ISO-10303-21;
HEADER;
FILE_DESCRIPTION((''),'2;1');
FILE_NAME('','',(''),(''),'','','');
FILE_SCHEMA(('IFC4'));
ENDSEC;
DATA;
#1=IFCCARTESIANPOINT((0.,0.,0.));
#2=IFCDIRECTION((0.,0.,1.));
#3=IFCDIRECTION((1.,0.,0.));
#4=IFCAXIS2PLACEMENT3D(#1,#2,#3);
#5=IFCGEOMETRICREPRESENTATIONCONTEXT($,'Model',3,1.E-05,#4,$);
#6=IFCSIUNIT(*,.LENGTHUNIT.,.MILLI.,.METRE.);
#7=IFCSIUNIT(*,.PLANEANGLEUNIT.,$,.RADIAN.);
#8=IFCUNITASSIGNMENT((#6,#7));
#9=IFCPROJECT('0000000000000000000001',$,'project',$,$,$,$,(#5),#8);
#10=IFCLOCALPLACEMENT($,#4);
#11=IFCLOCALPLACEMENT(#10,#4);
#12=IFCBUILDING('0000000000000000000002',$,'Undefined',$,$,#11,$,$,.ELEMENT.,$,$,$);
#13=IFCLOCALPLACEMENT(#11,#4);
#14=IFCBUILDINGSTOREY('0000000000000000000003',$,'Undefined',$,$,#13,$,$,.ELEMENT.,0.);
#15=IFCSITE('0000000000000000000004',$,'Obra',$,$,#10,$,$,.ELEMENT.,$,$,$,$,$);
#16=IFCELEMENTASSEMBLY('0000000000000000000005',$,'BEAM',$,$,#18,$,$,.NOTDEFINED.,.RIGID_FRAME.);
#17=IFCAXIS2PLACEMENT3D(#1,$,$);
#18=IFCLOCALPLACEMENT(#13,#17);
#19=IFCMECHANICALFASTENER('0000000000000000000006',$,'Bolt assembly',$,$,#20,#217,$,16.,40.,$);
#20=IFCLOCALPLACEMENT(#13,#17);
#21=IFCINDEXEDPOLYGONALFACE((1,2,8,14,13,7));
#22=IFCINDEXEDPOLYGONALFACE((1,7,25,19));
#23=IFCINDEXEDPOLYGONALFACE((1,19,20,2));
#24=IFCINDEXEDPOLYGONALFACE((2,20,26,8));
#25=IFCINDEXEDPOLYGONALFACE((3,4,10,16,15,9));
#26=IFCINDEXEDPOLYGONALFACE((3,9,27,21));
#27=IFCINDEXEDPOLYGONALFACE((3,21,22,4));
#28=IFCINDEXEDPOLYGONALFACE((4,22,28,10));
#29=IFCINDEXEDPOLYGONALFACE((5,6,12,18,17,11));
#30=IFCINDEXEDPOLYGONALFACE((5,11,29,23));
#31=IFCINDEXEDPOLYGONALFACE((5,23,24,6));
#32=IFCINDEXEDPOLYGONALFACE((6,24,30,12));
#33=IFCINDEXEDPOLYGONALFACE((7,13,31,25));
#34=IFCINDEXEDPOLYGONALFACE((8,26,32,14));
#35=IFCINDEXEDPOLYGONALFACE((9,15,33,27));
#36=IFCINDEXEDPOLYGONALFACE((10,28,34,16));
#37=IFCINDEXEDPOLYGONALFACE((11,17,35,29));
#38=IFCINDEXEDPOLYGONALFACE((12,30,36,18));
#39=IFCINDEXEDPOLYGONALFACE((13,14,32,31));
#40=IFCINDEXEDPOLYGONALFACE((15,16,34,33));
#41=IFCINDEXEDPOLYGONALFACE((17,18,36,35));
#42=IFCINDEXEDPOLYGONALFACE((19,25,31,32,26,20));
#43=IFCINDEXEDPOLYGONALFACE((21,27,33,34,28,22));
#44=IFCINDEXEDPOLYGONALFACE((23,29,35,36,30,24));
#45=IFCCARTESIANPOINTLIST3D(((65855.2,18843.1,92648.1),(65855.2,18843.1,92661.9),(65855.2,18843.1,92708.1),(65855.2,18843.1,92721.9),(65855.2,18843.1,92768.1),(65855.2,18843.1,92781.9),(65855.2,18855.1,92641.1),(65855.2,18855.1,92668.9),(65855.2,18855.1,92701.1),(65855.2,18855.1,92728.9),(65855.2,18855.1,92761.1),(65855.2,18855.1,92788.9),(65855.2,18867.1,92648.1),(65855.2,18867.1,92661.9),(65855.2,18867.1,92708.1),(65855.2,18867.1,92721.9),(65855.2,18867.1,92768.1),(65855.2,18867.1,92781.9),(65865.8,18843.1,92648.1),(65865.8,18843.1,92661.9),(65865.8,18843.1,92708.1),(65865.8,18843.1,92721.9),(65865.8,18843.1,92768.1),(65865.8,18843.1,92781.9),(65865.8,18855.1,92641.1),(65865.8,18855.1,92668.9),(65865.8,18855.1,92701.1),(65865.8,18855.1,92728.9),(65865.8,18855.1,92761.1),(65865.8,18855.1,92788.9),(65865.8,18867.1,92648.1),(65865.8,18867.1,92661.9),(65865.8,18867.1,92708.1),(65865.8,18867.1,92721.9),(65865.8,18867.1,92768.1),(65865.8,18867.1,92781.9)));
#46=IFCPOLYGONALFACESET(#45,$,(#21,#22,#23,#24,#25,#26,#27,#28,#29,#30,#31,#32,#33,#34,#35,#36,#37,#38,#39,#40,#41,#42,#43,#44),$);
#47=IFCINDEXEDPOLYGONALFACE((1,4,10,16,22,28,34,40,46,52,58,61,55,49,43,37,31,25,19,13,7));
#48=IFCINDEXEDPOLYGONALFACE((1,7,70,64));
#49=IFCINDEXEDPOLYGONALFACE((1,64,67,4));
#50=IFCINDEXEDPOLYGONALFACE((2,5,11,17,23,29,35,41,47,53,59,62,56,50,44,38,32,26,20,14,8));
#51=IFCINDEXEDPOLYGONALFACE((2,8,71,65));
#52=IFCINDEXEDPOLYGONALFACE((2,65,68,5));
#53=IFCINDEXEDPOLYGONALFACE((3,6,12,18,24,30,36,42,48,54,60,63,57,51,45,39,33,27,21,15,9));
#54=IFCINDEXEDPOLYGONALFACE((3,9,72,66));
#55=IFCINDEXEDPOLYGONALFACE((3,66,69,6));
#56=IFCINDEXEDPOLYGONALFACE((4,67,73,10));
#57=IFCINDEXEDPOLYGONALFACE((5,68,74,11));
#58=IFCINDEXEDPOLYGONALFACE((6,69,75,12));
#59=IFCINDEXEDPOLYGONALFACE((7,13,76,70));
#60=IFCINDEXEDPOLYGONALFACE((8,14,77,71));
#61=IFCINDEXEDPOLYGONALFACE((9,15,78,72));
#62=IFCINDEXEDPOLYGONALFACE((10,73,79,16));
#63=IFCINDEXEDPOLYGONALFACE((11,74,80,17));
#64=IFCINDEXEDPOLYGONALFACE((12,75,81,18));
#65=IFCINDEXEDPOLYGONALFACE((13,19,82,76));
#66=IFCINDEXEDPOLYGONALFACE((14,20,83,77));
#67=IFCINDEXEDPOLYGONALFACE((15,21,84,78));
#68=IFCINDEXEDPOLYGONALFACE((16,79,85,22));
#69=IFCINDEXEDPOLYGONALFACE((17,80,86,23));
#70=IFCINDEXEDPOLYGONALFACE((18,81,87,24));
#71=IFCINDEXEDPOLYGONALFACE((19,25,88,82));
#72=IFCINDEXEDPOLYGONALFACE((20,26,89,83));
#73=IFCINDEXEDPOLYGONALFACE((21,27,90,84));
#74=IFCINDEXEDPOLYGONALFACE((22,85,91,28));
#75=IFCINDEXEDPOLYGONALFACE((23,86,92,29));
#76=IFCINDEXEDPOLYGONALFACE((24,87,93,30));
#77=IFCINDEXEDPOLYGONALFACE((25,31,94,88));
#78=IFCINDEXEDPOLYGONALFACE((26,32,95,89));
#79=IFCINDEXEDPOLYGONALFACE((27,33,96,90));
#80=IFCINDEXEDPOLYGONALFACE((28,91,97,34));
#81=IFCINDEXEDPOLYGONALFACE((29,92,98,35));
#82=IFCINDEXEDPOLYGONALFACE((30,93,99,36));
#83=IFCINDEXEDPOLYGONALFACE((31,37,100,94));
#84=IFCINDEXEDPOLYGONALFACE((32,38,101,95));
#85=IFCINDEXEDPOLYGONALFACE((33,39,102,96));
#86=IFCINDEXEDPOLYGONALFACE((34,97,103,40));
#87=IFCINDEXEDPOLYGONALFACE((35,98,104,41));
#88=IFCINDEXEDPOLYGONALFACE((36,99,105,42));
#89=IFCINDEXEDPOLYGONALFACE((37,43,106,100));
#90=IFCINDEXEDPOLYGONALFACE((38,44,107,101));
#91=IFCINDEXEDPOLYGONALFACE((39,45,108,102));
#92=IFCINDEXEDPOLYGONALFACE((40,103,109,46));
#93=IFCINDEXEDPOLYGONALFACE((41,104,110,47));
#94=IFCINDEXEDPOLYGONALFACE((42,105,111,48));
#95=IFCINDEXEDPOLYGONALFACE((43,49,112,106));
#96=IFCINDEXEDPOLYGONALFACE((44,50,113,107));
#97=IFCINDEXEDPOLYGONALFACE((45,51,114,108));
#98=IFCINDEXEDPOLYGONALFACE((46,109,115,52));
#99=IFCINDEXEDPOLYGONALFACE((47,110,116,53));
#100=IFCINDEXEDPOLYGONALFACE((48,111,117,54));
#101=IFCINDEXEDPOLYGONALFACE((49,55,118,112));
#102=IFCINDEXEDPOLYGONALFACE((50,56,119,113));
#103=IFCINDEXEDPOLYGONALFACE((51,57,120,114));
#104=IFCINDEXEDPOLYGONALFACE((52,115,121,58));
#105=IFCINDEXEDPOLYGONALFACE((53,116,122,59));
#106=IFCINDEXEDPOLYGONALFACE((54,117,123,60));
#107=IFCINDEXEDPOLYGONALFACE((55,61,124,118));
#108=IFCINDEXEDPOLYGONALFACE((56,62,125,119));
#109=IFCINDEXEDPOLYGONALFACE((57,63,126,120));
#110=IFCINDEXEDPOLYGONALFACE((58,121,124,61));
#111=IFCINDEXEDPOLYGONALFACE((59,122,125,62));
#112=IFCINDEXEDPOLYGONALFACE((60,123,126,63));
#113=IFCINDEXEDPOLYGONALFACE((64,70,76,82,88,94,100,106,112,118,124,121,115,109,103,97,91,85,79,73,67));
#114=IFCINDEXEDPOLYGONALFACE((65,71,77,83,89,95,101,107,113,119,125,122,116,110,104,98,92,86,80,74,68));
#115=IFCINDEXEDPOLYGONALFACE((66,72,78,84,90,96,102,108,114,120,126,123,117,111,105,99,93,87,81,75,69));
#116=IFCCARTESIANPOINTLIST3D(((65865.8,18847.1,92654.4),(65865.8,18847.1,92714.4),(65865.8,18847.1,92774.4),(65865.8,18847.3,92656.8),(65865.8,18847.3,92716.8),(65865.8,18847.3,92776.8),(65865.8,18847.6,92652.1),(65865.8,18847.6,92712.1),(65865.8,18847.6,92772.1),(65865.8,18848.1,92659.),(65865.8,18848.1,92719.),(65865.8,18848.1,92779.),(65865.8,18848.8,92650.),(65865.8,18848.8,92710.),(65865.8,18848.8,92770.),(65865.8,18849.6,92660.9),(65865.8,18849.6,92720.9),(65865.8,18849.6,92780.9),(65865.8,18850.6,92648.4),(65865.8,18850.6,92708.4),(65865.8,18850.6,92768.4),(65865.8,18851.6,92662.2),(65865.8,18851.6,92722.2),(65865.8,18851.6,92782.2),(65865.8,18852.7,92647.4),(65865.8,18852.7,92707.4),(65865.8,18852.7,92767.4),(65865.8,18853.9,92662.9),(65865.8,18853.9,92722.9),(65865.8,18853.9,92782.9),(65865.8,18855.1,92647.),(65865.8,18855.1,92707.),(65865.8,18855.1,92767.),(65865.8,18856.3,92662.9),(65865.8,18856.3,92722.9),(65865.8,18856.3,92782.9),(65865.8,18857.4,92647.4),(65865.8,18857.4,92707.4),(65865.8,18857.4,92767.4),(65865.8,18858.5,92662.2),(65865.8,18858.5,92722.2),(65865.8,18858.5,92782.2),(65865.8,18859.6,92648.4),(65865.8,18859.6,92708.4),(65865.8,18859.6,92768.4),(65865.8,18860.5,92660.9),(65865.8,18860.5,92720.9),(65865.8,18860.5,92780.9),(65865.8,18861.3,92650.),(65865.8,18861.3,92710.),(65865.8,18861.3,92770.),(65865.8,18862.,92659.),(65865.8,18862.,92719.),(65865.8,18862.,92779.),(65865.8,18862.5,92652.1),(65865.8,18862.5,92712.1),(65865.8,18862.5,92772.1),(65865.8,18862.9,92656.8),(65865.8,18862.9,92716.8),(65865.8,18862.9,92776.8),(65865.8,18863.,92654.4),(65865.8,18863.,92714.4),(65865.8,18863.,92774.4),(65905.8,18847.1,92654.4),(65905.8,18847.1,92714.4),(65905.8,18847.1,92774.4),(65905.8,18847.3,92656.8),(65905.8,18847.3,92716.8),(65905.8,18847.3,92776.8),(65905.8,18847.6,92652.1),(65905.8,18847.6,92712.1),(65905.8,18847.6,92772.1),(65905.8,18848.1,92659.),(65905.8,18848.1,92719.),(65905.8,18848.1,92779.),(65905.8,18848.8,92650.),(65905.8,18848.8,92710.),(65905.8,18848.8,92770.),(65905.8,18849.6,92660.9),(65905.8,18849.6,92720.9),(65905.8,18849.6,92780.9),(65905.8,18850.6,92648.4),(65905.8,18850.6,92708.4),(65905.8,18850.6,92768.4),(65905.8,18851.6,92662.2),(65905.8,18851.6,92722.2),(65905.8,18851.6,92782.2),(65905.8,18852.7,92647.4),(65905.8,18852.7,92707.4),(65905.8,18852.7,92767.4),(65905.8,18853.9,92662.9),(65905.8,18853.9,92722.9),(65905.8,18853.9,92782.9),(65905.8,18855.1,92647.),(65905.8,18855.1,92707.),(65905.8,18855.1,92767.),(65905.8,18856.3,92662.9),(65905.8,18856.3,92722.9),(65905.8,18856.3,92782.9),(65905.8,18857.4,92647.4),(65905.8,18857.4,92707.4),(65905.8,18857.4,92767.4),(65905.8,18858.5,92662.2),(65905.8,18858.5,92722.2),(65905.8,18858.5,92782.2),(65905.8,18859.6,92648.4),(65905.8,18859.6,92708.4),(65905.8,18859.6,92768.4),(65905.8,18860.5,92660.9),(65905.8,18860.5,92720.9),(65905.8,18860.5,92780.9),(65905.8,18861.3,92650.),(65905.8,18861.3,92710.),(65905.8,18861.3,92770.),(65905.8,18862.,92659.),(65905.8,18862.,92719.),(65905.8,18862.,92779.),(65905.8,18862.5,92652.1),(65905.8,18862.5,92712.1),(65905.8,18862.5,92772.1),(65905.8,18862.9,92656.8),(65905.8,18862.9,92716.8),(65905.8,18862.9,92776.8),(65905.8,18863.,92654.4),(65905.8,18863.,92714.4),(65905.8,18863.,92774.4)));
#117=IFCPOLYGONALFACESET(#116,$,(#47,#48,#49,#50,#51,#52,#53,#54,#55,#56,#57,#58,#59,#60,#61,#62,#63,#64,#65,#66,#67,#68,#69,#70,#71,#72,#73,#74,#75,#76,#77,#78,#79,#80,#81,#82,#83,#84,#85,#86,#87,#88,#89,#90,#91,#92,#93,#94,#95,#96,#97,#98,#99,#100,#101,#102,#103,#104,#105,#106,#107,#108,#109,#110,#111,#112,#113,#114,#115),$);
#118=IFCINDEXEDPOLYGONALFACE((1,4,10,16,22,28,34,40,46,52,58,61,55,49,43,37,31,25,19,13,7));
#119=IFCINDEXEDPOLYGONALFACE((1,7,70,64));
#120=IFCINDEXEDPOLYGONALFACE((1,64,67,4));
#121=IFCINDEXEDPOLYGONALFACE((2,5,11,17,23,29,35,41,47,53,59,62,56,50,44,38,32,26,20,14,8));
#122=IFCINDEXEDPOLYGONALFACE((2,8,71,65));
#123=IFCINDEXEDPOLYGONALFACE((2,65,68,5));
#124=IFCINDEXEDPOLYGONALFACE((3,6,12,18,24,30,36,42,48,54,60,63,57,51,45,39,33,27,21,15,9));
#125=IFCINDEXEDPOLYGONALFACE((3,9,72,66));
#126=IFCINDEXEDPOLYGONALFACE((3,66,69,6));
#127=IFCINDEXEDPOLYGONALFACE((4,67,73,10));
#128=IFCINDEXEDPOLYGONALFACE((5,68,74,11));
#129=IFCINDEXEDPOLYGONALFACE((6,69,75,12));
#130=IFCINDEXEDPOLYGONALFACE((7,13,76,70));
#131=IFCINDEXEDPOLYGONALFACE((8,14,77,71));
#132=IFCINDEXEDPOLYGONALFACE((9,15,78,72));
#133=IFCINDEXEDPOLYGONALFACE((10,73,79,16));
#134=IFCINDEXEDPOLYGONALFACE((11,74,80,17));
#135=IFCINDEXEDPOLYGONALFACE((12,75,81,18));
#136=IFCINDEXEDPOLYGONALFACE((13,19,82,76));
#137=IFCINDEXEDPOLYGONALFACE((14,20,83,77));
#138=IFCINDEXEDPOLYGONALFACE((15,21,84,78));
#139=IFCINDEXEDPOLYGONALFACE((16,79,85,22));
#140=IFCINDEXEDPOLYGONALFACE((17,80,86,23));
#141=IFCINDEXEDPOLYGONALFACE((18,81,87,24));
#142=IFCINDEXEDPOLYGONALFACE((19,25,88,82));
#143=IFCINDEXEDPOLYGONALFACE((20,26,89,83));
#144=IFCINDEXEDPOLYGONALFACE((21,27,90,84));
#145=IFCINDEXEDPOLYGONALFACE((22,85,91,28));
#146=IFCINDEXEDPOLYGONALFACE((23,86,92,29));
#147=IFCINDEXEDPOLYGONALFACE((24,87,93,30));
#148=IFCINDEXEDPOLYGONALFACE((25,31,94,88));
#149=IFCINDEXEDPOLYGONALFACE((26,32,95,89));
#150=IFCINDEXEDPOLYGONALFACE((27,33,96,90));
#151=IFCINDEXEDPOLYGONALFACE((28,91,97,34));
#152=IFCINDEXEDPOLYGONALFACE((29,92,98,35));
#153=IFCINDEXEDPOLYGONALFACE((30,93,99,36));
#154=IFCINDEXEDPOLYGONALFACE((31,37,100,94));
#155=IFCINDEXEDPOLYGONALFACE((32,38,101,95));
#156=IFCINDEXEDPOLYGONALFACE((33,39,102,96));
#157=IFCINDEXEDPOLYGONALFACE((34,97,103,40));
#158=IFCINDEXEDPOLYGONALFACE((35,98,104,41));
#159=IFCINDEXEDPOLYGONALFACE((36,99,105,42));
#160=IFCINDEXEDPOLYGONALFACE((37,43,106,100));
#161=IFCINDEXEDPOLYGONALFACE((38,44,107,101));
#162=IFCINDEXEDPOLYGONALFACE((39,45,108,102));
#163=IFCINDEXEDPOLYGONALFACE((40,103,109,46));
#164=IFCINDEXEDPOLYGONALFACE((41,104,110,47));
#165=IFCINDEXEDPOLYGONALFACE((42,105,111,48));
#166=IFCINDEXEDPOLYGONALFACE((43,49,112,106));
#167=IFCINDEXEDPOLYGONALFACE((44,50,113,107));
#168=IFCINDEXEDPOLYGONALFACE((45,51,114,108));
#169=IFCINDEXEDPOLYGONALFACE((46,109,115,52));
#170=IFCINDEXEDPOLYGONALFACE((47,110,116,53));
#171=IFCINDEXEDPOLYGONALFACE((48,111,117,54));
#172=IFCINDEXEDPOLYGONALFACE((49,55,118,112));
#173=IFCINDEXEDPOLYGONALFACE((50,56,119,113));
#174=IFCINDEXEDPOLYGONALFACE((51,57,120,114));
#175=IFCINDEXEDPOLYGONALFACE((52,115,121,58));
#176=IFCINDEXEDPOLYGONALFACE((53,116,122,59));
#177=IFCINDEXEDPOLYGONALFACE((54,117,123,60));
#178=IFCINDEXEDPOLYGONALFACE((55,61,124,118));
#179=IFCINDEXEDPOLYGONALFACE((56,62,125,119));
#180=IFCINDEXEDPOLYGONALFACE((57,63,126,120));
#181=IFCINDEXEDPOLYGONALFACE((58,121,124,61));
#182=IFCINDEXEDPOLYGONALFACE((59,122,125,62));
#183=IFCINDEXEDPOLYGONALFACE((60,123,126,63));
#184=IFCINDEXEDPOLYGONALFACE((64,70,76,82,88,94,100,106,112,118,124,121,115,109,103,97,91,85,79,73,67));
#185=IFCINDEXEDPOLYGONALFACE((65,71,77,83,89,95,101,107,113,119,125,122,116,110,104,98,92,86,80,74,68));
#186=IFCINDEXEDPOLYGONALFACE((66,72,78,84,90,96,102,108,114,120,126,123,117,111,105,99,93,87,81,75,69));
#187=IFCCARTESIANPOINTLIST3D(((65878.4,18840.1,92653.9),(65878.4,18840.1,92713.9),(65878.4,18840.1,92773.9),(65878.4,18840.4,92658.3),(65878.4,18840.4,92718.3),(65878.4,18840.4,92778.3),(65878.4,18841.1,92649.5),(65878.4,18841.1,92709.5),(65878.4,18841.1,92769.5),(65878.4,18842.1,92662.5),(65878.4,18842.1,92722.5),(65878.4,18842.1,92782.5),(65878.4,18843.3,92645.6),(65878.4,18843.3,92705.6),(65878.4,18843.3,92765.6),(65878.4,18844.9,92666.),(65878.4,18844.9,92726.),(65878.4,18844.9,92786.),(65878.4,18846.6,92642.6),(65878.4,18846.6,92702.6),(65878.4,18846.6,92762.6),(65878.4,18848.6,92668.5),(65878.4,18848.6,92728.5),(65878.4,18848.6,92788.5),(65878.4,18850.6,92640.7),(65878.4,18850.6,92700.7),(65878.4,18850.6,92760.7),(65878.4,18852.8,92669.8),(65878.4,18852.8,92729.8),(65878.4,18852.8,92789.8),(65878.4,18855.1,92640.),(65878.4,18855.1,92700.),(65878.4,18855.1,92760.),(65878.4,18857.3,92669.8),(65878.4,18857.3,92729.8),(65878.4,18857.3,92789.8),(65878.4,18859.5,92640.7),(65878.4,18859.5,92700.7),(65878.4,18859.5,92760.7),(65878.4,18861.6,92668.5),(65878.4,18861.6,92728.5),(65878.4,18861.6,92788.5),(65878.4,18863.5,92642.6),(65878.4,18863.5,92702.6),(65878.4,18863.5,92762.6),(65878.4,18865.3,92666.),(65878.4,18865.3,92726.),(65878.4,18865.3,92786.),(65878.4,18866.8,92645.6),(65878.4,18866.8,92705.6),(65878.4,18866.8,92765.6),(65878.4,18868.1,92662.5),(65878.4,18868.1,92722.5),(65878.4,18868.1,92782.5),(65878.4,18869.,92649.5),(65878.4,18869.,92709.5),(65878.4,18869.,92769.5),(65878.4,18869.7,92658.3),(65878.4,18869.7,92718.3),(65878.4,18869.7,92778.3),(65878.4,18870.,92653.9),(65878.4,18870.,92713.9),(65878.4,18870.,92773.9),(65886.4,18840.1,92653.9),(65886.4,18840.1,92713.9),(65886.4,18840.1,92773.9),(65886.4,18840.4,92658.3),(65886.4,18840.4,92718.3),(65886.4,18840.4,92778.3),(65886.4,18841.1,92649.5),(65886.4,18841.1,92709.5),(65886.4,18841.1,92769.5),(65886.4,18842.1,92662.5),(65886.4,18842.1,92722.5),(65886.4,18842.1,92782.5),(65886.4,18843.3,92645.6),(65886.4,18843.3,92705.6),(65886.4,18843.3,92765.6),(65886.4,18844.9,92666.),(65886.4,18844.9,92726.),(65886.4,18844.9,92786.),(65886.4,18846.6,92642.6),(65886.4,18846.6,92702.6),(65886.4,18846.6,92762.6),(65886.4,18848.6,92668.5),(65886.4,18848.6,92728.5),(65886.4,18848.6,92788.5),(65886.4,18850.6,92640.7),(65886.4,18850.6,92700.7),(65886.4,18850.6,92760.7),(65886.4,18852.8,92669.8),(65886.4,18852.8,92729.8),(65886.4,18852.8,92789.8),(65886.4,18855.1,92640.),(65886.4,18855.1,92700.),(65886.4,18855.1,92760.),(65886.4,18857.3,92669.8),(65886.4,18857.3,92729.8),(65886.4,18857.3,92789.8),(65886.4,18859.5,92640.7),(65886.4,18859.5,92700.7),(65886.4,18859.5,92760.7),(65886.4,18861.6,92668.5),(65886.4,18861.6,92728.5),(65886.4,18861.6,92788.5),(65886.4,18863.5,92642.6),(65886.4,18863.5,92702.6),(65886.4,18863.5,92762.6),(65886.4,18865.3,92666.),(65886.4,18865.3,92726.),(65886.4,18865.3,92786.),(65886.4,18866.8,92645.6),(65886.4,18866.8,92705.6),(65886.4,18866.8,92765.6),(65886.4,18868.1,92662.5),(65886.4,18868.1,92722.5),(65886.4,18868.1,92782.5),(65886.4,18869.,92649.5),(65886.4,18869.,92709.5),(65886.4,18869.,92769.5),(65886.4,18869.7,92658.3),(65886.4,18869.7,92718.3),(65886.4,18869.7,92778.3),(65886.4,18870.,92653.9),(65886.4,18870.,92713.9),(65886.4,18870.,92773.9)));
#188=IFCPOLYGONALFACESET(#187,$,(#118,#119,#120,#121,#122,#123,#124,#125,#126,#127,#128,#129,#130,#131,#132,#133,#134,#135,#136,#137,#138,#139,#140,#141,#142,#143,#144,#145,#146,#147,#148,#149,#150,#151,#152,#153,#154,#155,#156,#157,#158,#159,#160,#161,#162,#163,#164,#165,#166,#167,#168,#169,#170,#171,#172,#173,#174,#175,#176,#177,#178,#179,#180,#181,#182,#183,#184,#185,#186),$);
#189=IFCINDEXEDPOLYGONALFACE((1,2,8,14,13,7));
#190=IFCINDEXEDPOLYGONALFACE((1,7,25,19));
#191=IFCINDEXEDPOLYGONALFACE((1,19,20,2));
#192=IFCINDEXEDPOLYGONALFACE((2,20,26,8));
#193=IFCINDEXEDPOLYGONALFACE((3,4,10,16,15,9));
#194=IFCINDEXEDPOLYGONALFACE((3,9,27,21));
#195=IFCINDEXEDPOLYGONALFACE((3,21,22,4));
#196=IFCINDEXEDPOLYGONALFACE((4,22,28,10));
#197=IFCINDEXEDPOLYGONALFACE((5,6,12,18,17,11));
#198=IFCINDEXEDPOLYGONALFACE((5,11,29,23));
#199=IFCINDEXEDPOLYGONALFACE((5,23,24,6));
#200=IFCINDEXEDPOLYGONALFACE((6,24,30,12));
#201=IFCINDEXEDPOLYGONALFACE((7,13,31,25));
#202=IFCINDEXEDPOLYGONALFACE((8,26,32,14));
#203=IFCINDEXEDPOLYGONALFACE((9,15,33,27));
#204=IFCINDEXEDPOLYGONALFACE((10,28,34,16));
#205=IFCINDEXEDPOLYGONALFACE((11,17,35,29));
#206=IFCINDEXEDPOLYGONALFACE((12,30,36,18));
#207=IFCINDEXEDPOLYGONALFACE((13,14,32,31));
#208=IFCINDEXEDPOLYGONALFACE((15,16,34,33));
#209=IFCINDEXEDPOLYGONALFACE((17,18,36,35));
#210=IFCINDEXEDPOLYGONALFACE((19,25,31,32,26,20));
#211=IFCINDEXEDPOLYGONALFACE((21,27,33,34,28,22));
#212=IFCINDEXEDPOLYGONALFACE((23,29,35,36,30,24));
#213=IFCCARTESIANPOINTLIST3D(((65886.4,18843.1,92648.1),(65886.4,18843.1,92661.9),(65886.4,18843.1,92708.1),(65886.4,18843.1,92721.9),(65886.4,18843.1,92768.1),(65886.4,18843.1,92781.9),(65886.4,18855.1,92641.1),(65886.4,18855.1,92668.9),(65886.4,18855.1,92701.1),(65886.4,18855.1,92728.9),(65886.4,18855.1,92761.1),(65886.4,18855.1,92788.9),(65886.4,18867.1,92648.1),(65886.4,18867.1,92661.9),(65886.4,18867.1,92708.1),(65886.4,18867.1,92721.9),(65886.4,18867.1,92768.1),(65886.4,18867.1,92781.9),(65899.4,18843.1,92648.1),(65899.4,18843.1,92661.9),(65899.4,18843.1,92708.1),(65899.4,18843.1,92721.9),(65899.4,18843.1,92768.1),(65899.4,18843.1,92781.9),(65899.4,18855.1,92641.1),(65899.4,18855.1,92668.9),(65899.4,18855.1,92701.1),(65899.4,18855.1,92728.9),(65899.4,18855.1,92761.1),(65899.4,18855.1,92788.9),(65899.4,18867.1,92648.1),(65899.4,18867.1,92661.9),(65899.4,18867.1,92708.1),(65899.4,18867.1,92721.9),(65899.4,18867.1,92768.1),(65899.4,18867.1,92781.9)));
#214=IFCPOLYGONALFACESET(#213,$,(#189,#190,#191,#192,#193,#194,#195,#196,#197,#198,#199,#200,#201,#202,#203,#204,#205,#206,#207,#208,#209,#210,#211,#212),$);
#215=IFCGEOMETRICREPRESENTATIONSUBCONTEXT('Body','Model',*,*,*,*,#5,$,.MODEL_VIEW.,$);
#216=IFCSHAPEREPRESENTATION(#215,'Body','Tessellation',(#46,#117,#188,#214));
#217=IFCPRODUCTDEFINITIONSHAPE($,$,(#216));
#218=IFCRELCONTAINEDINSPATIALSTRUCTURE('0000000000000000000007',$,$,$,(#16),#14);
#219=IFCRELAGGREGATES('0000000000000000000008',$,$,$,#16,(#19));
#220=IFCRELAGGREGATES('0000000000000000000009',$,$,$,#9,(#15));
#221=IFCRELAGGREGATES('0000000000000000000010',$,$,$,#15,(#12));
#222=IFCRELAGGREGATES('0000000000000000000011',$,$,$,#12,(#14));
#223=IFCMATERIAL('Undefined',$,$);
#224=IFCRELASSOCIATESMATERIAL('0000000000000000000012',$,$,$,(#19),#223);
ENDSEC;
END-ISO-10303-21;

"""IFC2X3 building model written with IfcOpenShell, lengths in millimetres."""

from ifc_helpers import new_model, si_unit, frame, origin_with_axes, origin_2d_with_axis, place, context, subcontext, project, spatial, polyline, circle, outline, extrude, source, transform, mapped, material, element, aggregate, save


model = new_model("IFC2X3")

# Units and contexts
model_context = context("Model", 3, precision=1e-05, world=origin_with_axes())
body_context = subcontext(model_context, "Body", "Model", "MODEL_VIEW")
ifc_project = project(units=[si_unit("LENGTHUNIT", "METRE", prefix="MILLI"), si_unit("PLANEANGLEUNIT", "RADIAN")], contexts=[model_context])

# Site, building, storey
site_placement = place(None, origin_with_axes())
site = spatial("IfcSite", under=ifc_project, at=site_placement, Name="Obra", CompositionType="ELEMENT")
building_placement = place(site_placement, origin_with_axes())
building = spatial("IfcBuilding", under=site, at=building_placement, Name="Undefined", CompositionType="ELEMENT")
storey_placement = place(building_placement, origin_with_axes())
storey = spatial("IfcBuildingStorey", under=building, at=storey_placement, Name="Undefined", CompositionType="ELEMENT", Elevation=0.0)

# Shared definitions
ifc_material_1 = material(Name="Undefined")

# Element assembly, mechanical fastener
assembly_1_placement = place(storey_placement, origin_with_axes())
assembly_1 = element("IfcElementAssembly", 1, at=assembly_1_placement, inside=storey, Name="BEAM", AssemblyPlace="NOTDEFINED", PredefinedType="RIGID_FRAME")
shared_shape_1 = source(origin_with_axes(), body_context, "Body", "SweptSolid", [
    extrude(outline(polyline([(13.9, 0.0), (6.9, 12.0), (-6.9, 12.0), (-13.9, 0.0), (-6.9, -12.0), (6.9, -12.0), (13.9, 0.0)])), frame((0.0, -19.9, 0.0), z_axis=(0.0, 1.0, 0.0), x_axis=(1.0, 0.0, 0.0)), (0.0, 0.0, 1.0), 10.6),
    extrude(circle(Radius=8.0, at=origin_2d_with_axis()), frame((0.0, -9.3, 0.0), z_axis=(0.0, 1.0, 0.0), x_axis=(1.0, 0.0, 0.0)), (0.0, 0.0, 1.0), 40.0),
    extrude(circle(Radius=15.0, at=origin_2d_with_axis()), frame((0.0, 3.3, 0.0), z_axis=(0.0, 1.0, 0.0), x_axis=(1.0, 0.0, 0.0)), (0.0, 0.0, 1.0), 8.0),
    extrude(outline(polyline([(13.9, 0.0), (6.9, 12.0), (-6.9, 12.0), (-13.9, 0.0), (-6.9, -12.0), (6.9, -12.0), (13.9, 0.0)])), frame((0.0, 11.3, 0.0), z_axis=(0.0, 1.0, 0.0), x_axis=(1.0, 0.0, 0.0)), (0.0, 0.0, 1.0), 13.0),
])
mechanical_fastener_1_placement = place(assembly_1_placement, frame((65875.1, 18905.1, 92850.0), z_axis=(0.000002, -1.0, 0.0), x_axis=(0.0, 0.0, -1.0)))
mechanical_fastener_1 = element("IfcMechanicalFastener", 2, at=mechanical_fastener_1_placement, material=ifc_material_1, Name="Bolt assembly", NominalDiameter=16.0, NominalLength=40.0, context=body_context, shape_type="MappedRepresentation", body=[
    mapped(shared_shape_1, transform((75.0, 0.0, 50.0))),
    mapped(shared_shape_1, transform((135.0, 0.0, 50.0))),
    mapped(shared_shape_1, transform((195.0, 0.0, 50.0))),
])
aggregate(assembly_1, [mechanical_fastener_1])

save(model, "model.ifc")
